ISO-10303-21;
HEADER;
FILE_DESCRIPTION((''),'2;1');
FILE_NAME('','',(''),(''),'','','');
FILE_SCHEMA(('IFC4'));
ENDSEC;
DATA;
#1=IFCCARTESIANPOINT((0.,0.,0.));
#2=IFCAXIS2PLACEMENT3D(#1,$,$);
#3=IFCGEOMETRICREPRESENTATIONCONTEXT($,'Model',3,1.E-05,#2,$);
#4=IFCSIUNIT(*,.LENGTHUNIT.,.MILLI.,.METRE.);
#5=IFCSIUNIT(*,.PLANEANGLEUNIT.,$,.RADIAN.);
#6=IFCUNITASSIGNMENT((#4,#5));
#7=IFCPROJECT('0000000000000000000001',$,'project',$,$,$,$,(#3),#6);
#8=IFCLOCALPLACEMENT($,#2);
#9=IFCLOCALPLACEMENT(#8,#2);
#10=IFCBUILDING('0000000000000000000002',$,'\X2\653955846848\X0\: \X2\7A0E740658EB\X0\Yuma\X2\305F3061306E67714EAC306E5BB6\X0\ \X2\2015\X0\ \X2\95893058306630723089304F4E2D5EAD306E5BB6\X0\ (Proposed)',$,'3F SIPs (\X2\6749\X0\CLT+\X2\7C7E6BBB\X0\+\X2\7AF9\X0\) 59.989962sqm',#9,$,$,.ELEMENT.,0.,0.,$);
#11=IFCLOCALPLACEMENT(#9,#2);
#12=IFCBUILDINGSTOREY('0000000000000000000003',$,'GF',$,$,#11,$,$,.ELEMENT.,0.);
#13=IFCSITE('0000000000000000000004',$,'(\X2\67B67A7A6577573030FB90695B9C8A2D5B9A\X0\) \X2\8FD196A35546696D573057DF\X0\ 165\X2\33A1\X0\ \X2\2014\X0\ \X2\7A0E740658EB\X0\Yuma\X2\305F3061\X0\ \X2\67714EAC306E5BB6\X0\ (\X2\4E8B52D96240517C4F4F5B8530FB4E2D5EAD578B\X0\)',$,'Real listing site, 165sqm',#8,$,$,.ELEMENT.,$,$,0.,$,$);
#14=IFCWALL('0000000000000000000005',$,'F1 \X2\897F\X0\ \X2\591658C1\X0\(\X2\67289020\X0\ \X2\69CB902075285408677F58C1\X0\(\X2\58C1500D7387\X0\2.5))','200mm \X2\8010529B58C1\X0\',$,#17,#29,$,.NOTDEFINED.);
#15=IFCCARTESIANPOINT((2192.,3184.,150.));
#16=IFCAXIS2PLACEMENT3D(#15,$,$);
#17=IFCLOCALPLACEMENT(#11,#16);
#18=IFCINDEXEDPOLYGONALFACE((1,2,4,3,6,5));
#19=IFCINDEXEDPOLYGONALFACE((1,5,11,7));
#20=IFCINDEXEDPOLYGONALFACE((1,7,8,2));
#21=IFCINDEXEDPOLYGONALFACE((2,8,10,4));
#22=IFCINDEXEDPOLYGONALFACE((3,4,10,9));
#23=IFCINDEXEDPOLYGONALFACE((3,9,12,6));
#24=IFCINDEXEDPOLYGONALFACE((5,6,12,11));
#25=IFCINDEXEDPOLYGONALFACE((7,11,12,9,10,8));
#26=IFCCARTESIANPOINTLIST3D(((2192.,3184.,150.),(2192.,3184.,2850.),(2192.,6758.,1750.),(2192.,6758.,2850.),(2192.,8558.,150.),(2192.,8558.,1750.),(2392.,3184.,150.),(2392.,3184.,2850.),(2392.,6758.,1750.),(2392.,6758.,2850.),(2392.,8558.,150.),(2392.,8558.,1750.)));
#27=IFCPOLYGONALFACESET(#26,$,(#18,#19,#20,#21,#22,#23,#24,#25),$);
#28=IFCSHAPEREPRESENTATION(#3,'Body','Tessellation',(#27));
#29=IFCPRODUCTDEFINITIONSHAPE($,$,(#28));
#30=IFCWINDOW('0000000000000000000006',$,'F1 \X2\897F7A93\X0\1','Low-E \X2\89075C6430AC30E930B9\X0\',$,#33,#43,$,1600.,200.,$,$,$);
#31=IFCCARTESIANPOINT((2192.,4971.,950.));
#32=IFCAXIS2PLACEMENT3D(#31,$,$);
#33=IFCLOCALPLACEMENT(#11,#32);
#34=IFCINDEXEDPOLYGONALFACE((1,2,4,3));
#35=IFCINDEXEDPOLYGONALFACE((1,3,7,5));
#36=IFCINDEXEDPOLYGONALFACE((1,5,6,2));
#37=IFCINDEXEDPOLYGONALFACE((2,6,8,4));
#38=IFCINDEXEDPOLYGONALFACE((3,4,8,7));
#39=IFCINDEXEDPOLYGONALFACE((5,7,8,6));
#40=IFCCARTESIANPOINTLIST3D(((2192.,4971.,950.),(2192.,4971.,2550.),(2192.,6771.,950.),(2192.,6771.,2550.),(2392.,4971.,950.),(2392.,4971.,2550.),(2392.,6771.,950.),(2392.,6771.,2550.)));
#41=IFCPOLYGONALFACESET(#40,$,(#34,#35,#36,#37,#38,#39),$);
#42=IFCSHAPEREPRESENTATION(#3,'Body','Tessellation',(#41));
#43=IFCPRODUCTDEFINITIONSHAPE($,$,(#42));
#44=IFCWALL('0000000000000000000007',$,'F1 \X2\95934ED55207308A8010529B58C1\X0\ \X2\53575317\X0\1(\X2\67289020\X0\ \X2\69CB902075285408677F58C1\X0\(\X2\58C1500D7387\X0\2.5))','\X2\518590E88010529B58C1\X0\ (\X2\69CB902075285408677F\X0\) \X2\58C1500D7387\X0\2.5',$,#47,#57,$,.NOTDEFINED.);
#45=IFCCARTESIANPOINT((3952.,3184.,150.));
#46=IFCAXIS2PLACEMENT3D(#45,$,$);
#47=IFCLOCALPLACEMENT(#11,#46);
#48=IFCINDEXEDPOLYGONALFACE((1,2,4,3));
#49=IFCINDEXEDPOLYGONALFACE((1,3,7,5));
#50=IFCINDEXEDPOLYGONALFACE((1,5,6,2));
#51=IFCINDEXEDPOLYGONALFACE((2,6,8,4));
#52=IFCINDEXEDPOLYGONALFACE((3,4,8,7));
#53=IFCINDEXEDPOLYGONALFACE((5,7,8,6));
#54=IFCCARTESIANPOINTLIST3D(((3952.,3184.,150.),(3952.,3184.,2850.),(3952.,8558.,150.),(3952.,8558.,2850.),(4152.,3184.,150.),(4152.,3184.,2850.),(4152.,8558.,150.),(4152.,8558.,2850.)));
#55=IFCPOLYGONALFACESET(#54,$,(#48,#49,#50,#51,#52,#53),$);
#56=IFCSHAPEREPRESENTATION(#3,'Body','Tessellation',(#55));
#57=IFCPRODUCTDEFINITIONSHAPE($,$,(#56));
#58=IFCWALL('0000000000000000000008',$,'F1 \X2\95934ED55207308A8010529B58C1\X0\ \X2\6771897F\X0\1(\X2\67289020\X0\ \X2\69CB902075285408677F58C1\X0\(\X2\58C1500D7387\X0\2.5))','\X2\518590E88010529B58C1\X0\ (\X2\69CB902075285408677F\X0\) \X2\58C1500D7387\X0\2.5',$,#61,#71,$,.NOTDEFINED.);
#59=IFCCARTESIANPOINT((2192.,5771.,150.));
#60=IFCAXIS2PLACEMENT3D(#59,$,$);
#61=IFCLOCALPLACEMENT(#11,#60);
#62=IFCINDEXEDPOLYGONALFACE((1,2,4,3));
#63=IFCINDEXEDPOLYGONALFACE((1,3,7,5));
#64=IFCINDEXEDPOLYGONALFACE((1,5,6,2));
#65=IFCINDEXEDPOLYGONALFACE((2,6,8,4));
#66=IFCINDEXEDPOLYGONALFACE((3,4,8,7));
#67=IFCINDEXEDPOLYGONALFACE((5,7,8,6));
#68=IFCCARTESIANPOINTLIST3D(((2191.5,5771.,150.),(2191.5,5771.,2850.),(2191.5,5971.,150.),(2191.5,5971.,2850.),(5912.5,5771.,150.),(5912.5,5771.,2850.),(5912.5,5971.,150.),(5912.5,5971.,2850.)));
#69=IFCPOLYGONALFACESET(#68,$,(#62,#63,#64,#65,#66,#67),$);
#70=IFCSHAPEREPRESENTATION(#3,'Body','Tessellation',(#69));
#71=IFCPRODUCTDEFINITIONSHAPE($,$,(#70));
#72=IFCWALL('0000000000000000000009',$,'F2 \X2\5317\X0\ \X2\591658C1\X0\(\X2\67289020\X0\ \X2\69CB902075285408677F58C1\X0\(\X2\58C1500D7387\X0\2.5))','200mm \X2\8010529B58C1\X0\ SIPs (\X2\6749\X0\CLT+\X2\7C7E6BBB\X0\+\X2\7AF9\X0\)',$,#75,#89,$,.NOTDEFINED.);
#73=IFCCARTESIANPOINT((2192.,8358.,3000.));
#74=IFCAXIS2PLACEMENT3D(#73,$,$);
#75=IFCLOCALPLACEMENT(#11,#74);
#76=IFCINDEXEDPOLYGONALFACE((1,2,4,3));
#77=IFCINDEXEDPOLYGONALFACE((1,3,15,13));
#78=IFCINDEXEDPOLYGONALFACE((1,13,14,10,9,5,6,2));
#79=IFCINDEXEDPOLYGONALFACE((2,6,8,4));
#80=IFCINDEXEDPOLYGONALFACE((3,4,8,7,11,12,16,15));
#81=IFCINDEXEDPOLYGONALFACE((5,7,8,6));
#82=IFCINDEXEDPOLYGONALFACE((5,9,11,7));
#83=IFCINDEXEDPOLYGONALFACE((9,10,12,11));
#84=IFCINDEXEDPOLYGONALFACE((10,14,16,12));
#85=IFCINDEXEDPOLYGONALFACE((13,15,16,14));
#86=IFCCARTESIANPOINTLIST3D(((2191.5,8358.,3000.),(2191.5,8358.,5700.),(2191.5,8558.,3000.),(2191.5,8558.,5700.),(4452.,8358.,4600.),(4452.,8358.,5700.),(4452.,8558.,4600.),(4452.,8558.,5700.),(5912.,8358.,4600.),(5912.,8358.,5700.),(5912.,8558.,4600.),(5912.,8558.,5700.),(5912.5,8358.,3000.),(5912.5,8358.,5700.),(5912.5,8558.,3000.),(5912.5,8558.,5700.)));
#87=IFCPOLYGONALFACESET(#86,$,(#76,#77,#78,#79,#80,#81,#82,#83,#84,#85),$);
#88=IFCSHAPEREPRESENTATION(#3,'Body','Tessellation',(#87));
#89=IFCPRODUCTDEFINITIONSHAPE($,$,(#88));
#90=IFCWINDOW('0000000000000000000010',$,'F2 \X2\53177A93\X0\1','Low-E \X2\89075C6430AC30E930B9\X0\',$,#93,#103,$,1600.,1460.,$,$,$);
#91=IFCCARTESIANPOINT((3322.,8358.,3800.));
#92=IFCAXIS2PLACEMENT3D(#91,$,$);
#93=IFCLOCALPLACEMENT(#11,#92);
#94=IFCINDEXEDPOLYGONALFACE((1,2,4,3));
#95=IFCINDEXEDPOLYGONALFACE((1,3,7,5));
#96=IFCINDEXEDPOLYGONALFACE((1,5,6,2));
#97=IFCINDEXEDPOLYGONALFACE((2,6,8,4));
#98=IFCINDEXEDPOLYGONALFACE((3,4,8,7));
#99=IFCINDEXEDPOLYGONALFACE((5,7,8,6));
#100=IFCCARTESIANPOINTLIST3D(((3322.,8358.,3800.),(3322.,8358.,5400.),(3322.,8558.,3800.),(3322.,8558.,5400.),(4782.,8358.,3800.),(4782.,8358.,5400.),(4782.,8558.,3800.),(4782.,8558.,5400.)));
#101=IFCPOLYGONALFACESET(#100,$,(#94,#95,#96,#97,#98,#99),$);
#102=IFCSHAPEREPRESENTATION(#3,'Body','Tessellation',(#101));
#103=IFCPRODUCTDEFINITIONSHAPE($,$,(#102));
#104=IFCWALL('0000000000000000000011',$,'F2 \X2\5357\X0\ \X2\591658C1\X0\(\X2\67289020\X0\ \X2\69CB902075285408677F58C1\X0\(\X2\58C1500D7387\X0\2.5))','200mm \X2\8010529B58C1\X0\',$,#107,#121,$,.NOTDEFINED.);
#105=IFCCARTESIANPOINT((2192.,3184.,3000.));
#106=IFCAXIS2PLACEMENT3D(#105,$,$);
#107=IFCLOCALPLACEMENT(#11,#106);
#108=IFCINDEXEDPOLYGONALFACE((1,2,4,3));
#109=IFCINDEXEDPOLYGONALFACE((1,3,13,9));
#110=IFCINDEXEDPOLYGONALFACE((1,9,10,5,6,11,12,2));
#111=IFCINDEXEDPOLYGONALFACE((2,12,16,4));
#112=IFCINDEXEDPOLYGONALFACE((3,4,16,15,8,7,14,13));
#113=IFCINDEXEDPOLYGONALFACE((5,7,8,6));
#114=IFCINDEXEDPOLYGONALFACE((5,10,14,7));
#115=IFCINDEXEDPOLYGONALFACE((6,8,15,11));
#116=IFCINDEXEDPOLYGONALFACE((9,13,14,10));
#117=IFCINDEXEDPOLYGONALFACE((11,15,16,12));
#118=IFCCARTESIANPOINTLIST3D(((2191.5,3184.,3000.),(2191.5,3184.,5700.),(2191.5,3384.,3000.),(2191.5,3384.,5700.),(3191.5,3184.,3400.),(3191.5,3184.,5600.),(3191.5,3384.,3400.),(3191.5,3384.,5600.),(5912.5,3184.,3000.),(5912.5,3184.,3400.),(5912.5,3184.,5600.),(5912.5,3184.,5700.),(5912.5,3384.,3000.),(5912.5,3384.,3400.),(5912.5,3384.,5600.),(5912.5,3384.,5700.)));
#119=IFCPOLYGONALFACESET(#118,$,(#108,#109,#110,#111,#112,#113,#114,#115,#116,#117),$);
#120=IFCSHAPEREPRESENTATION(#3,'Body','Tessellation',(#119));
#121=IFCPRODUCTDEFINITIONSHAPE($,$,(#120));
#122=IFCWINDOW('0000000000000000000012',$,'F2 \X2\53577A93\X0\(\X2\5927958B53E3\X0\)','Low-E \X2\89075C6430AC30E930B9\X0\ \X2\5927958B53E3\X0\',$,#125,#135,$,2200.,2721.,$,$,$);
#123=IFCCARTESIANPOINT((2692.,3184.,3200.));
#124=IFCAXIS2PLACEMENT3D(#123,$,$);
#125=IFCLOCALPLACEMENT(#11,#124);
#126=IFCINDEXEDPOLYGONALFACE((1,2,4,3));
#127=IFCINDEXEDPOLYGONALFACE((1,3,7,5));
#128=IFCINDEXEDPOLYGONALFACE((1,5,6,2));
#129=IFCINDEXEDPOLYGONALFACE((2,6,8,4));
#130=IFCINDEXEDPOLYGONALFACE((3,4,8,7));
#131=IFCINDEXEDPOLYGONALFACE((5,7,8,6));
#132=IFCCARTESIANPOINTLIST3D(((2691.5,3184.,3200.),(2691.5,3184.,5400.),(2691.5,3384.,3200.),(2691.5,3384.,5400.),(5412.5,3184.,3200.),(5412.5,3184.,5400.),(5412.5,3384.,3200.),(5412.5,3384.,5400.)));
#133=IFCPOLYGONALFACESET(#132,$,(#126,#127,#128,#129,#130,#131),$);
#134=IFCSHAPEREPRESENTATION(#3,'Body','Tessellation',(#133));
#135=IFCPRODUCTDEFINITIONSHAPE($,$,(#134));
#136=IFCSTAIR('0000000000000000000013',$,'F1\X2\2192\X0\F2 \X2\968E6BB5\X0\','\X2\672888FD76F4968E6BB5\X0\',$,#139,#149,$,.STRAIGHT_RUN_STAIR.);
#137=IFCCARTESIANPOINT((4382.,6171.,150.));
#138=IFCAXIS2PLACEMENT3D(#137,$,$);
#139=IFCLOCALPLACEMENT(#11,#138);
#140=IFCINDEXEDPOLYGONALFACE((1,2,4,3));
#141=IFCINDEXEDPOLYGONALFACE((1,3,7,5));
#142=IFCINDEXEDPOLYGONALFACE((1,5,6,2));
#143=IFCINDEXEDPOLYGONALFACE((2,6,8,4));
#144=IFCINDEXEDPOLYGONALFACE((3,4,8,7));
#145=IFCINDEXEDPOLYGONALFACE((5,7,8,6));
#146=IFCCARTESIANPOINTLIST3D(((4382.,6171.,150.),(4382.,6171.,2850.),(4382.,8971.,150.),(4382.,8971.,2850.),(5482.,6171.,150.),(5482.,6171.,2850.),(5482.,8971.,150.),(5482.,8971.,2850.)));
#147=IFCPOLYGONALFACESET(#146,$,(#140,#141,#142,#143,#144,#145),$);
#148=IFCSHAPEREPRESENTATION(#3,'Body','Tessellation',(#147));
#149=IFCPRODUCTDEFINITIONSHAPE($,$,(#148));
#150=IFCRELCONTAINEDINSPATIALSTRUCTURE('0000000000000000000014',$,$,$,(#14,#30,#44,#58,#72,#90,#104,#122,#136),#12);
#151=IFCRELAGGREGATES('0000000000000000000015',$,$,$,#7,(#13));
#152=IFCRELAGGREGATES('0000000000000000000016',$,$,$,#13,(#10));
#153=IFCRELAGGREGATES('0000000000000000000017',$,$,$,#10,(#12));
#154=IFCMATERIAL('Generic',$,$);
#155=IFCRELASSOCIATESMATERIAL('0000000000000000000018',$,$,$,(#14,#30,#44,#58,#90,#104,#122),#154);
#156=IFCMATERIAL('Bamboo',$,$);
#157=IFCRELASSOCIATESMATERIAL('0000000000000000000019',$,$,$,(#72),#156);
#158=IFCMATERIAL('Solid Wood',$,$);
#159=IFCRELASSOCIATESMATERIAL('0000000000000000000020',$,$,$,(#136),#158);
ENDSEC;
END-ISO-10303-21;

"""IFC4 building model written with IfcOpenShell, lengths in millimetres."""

from ifc_helpers import new_model, si_unit, frame, frame_2d, origin, place, context, project, spatial, rectangle, extrude, material, element, fill, save


model = new_model("IFC4")

# Units and contexts
model_context = context("Model", 3, precision=1e-05, world=origin())
ifc_project = project(units=[si_unit("LENGTHUNIT", "METRE", prefix="MILLI"), si_unit("PLANEANGLEUNIT", "RADIAN")], contexts=[model_context])

# Site, building, storey
site_placement = place(None, origin())
site = spatial("IfcSite", under=ifc_project, at=site_placement, Name="(架空敷地・適宜設定) 近隣商業地域 165㎡ — 税理士Yumaたち 東京の家 (事務所兼住宅・中庭型)", ObjectType="Real listing site, 165sqm", CompositionType="ELEMENT", RefElevation=0.0)
building_placement = place(site_placement, origin())
building = spatial("IfcBuilding", under=site, at=building_placement, Name="改善案: 税理士Yumaたちの東京の家 ― 閉じてひらく中庭の家 (Proposed)", ObjectType="3F SIPs (杉CLT+籾殻+竹) 59.989962sqm", CompositionType="ELEMENT", ElevationOfRefHeight=0.0, ElevationOfTerrain=0.0)
storey_placement = place(building_placement, origin())
storey = spatial("IfcBuildingStorey", under=building, at=storey_placement, Name="GF", CompositionType="ELEMENT", Elevation=0.0)

# Shared definitions
ifc_material_1 = material(Name="Generic")

# Shared definitions
ifc_material_2 = material(Name="Bamboo")

# Shared definitions
ifc_material_3 = material(Name="Solid Wood")

# Wall, opening, window
wall_1_placement = place(storey_placement, frame((2192.0, 3184.0, 150.0)))
wall_1 = element("IfcWall", 1, at=wall_1_placement, inside=storey, material=ifc_material_1, Name="F1 西 外壁(木造 構造用合板壁(壁倍率2.5))", Description="200mm 耐力壁", PredefinedType="NOTDEFINED", context=model_context, shape_type="SweptSolid", body=[
    extrude(rectangle(XDim=200.0, YDim=5374.0, at=frame_2d((100.0, 2687.0))), frame((2192.0, 3184.0, 150.0)), (0.0, 0.0, 1.0), 2700.0),
])
opening_1_placement = place(storey_placement, frame((2192.0, 4971.0, 950.0)))
opening_1 = element("IfcOpeningElement", 2, at=opening_1_placement, cuts=wall_1, PredefinedType="NOTDEFINED", context=model_context, shape_type="SweptSolid", body=[
    extrude(rectangle(XDim=200.0, YDim=1800.0, at=frame_2d((100.0, 900.0))), frame((2192.0, 4971.0, 950.0)), (0.0, 0.0, 1.0), 1600.0),
])
window_1_placement = place(storey_placement, frame((2192.0, 4971.0, 950.0)))
window_1 = element("IfcWindow", 3, at=window_1_placement, inside=storey, material=ifc_material_1, Name="F1 西窓1", Description="Low-E 複層ガラス", OverallHeight=1600.0, OverallWidth=200.0, context=model_context, shape_type="SweptSolid", body=[
    extrude(rectangle(XDim=200.0, YDim=1800.0, at=frame_2d((100.0, 900.0))), frame((2192.0, 4971.0, 950.0)), (0.0, 0.0, 1.0), 1600.0),
])
fill(opening_1, window_1)

# Walls
wall_2_placement = place(storey_placement, frame((3952.0, 3184.0, 150.0)))
element("IfcWall", 4, at=wall_2_placement, inside=storey, material=ifc_material_1, Name="F1 間仕切り耐力壁 南北1(木造 構造用合板壁(壁倍率2.5))", Description="内部耐力壁 (構造用合板) 壁倍率2.5", PredefinedType="NOTDEFINED", context=model_context, shape_type="SweptSolid", body=[
    extrude(rectangle(XDim=200.0, YDim=5374.0, at=frame_2d((100.0, 2687.0))), frame((3952.0, 3184.0, 150.0)), (0.0, 0.0, 1.0), 2700.0),
])
wall_3_placement = place(storey_placement, frame((2192.0, 5771.0, 150.0)))
element("IfcWall", 5, at=wall_3_placement, inside=storey, material=ifc_material_1, Name="F1 間仕切り耐力壁 東西1(木造 構造用合板壁(壁倍率2.5))", Description="内部耐力壁 (構造用合板) 壁倍率2.5", PredefinedType="NOTDEFINED", context=model_context, shape_type="SweptSolid", body=[
    extrude(rectangle(XDim=3721.0, YDim=200.0, at=frame_2d((1860.0, 100.0))), frame((2192.0, 5771.0, 150.0)), (0.0, 0.0, 1.0), 2700.0),
])

# Walls, openings, windows
wall_4_placement = place(storey_placement, frame((2192.0, 8358.0, 3000.0)))
wall_4 = element("IfcWall", 6, at=wall_4_placement, inside=storey, material=ifc_material_2, Name="F2 北 外壁(木造 構造用合板壁(壁倍率2.5))", Description="200mm 耐力壁 SIPs (杉CLT+籾殻+竹)", PredefinedType="NOTDEFINED", context=model_context, shape_type="SweptSolid", body=[
    extrude(rectangle(XDim=3721.0, YDim=200.0, at=frame_2d((1860.0, 100.0))), frame((2192.0, 8358.0, 3000.0)), (0.0, 0.0, 1.0), 2700.0),
])
opening_2_placement = place(storey_placement, frame((3322.0, 8358.0, 3800.0)))
opening_2 = element("IfcOpeningElement", 7, at=opening_2_placement, cuts=wall_4, PredefinedType="NOTDEFINED", context=model_context, shape_type="SweptSolid", body=[
    extrude(rectangle(XDim=1460.0, YDim=200.0, at=frame_2d((730.0, 100.0))), frame((3322.0, 8358.0, 3800.0)), (0.0, 0.0, 1.0), 1600.0),
])
window_2_placement = place(storey_placement, frame((3322.0, 8358.0, 3800.0)))
window_2 = element("IfcWindow", 8, at=window_2_placement, inside=storey, material=ifc_material_1, Name="F2 北窓1", Description="Low-E 複層ガラス", OverallHeight=1600.0, OverallWidth=1460.0, context=model_context, shape_type="SweptSolid", body=[
    extrude(rectangle(XDim=1460.0, YDim=200.0, at=frame_2d((730.0, 100.0))), frame((3322.0, 8358.0, 3800.0)), (0.0, 0.0, 1.0), 1600.0),
])
fill(opening_2, window_2)
wall_5_placement = place(storey_placement, frame((2192.0, 3184.0, 3000.0)))
wall_5 = element("IfcWall", 9, at=wall_5_placement, inside=storey, material=ifc_material_1, Name="F2 南 外壁(木造 構造用合板壁(壁倍率2.5))", Description="200mm 耐力壁", PredefinedType="NOTDEFINED", context=model_context, shape_type="SweptSolid", body=[
    extrude(rectangle(XDim=3721.0, YDim=200.0, at=frame_2d((1860.0, 100.0))), frame((2192.0, 3184.0, 3000.0)), (0.0, 0.0, 1.0), 2700.0),
])
opening_3_placement = place(storey_placement, frame((2692.0, 3184.0, 3200.0)))
opening_3 = element("IfcOpeningElement", 10, at=opening_3_placement, cuts=wall_5, PredefinedType="NOTDEFINED", context=model_context, shape_type="SweptSolid", body=[
    extrude(rectangle(XDim=2721.0, YDim=200.0, at=frame_2d((1360.0, 100.0))), frame((2692.0, 3184.0, 3200.0)), (0.0, 0.0, 1.0), 2200.0),
])
window_3_placement = place(storey_placement, frame((2692.0, 3184.0, 3200.0)))
window_3 = element("IfcWindow", 11, at=window_3_placement, inside=storey, material=ifc_material_1, Name="F2 南窓(大開口)", Description="Low-E 複層ガラス 大開口", OverallHeight=2200.0, OverallWidth=2721.0, context=model_context, shape_type="SweptSolid", body=[
    extrude(rectangle(XDim=2721.0, YDim=200.0, at=frame_2d((1360.0, 100.0))), frame((2692.0, 3184.0, 3200.0)), (0.0, 0.0, 1.0), 2200.0),
])
fill(opening_3, window_3)

# Stair
stair_placement = place(storey_placement, frame((4382.0, 6171.0, 150.0)))
element("IfcStair", 12, at=stair_placement, inside=storey, material=ifc_material_3, Name="F1→F2 階段", Description="木製直階段", PredefinedType="STRAIGHT_RUN_STAIR", context=model_context, shape_type="SweptSolid", body=[
    extrude(rectangle(XDim=1100.0, YDim=2800.0, at=frame_2d((550.0, 1400.0))), frame((4382.0, 6171.0, 150.0)), (0.0, 0.0, 1.0), 2700.0),
])

save(model, "model.ifc")
